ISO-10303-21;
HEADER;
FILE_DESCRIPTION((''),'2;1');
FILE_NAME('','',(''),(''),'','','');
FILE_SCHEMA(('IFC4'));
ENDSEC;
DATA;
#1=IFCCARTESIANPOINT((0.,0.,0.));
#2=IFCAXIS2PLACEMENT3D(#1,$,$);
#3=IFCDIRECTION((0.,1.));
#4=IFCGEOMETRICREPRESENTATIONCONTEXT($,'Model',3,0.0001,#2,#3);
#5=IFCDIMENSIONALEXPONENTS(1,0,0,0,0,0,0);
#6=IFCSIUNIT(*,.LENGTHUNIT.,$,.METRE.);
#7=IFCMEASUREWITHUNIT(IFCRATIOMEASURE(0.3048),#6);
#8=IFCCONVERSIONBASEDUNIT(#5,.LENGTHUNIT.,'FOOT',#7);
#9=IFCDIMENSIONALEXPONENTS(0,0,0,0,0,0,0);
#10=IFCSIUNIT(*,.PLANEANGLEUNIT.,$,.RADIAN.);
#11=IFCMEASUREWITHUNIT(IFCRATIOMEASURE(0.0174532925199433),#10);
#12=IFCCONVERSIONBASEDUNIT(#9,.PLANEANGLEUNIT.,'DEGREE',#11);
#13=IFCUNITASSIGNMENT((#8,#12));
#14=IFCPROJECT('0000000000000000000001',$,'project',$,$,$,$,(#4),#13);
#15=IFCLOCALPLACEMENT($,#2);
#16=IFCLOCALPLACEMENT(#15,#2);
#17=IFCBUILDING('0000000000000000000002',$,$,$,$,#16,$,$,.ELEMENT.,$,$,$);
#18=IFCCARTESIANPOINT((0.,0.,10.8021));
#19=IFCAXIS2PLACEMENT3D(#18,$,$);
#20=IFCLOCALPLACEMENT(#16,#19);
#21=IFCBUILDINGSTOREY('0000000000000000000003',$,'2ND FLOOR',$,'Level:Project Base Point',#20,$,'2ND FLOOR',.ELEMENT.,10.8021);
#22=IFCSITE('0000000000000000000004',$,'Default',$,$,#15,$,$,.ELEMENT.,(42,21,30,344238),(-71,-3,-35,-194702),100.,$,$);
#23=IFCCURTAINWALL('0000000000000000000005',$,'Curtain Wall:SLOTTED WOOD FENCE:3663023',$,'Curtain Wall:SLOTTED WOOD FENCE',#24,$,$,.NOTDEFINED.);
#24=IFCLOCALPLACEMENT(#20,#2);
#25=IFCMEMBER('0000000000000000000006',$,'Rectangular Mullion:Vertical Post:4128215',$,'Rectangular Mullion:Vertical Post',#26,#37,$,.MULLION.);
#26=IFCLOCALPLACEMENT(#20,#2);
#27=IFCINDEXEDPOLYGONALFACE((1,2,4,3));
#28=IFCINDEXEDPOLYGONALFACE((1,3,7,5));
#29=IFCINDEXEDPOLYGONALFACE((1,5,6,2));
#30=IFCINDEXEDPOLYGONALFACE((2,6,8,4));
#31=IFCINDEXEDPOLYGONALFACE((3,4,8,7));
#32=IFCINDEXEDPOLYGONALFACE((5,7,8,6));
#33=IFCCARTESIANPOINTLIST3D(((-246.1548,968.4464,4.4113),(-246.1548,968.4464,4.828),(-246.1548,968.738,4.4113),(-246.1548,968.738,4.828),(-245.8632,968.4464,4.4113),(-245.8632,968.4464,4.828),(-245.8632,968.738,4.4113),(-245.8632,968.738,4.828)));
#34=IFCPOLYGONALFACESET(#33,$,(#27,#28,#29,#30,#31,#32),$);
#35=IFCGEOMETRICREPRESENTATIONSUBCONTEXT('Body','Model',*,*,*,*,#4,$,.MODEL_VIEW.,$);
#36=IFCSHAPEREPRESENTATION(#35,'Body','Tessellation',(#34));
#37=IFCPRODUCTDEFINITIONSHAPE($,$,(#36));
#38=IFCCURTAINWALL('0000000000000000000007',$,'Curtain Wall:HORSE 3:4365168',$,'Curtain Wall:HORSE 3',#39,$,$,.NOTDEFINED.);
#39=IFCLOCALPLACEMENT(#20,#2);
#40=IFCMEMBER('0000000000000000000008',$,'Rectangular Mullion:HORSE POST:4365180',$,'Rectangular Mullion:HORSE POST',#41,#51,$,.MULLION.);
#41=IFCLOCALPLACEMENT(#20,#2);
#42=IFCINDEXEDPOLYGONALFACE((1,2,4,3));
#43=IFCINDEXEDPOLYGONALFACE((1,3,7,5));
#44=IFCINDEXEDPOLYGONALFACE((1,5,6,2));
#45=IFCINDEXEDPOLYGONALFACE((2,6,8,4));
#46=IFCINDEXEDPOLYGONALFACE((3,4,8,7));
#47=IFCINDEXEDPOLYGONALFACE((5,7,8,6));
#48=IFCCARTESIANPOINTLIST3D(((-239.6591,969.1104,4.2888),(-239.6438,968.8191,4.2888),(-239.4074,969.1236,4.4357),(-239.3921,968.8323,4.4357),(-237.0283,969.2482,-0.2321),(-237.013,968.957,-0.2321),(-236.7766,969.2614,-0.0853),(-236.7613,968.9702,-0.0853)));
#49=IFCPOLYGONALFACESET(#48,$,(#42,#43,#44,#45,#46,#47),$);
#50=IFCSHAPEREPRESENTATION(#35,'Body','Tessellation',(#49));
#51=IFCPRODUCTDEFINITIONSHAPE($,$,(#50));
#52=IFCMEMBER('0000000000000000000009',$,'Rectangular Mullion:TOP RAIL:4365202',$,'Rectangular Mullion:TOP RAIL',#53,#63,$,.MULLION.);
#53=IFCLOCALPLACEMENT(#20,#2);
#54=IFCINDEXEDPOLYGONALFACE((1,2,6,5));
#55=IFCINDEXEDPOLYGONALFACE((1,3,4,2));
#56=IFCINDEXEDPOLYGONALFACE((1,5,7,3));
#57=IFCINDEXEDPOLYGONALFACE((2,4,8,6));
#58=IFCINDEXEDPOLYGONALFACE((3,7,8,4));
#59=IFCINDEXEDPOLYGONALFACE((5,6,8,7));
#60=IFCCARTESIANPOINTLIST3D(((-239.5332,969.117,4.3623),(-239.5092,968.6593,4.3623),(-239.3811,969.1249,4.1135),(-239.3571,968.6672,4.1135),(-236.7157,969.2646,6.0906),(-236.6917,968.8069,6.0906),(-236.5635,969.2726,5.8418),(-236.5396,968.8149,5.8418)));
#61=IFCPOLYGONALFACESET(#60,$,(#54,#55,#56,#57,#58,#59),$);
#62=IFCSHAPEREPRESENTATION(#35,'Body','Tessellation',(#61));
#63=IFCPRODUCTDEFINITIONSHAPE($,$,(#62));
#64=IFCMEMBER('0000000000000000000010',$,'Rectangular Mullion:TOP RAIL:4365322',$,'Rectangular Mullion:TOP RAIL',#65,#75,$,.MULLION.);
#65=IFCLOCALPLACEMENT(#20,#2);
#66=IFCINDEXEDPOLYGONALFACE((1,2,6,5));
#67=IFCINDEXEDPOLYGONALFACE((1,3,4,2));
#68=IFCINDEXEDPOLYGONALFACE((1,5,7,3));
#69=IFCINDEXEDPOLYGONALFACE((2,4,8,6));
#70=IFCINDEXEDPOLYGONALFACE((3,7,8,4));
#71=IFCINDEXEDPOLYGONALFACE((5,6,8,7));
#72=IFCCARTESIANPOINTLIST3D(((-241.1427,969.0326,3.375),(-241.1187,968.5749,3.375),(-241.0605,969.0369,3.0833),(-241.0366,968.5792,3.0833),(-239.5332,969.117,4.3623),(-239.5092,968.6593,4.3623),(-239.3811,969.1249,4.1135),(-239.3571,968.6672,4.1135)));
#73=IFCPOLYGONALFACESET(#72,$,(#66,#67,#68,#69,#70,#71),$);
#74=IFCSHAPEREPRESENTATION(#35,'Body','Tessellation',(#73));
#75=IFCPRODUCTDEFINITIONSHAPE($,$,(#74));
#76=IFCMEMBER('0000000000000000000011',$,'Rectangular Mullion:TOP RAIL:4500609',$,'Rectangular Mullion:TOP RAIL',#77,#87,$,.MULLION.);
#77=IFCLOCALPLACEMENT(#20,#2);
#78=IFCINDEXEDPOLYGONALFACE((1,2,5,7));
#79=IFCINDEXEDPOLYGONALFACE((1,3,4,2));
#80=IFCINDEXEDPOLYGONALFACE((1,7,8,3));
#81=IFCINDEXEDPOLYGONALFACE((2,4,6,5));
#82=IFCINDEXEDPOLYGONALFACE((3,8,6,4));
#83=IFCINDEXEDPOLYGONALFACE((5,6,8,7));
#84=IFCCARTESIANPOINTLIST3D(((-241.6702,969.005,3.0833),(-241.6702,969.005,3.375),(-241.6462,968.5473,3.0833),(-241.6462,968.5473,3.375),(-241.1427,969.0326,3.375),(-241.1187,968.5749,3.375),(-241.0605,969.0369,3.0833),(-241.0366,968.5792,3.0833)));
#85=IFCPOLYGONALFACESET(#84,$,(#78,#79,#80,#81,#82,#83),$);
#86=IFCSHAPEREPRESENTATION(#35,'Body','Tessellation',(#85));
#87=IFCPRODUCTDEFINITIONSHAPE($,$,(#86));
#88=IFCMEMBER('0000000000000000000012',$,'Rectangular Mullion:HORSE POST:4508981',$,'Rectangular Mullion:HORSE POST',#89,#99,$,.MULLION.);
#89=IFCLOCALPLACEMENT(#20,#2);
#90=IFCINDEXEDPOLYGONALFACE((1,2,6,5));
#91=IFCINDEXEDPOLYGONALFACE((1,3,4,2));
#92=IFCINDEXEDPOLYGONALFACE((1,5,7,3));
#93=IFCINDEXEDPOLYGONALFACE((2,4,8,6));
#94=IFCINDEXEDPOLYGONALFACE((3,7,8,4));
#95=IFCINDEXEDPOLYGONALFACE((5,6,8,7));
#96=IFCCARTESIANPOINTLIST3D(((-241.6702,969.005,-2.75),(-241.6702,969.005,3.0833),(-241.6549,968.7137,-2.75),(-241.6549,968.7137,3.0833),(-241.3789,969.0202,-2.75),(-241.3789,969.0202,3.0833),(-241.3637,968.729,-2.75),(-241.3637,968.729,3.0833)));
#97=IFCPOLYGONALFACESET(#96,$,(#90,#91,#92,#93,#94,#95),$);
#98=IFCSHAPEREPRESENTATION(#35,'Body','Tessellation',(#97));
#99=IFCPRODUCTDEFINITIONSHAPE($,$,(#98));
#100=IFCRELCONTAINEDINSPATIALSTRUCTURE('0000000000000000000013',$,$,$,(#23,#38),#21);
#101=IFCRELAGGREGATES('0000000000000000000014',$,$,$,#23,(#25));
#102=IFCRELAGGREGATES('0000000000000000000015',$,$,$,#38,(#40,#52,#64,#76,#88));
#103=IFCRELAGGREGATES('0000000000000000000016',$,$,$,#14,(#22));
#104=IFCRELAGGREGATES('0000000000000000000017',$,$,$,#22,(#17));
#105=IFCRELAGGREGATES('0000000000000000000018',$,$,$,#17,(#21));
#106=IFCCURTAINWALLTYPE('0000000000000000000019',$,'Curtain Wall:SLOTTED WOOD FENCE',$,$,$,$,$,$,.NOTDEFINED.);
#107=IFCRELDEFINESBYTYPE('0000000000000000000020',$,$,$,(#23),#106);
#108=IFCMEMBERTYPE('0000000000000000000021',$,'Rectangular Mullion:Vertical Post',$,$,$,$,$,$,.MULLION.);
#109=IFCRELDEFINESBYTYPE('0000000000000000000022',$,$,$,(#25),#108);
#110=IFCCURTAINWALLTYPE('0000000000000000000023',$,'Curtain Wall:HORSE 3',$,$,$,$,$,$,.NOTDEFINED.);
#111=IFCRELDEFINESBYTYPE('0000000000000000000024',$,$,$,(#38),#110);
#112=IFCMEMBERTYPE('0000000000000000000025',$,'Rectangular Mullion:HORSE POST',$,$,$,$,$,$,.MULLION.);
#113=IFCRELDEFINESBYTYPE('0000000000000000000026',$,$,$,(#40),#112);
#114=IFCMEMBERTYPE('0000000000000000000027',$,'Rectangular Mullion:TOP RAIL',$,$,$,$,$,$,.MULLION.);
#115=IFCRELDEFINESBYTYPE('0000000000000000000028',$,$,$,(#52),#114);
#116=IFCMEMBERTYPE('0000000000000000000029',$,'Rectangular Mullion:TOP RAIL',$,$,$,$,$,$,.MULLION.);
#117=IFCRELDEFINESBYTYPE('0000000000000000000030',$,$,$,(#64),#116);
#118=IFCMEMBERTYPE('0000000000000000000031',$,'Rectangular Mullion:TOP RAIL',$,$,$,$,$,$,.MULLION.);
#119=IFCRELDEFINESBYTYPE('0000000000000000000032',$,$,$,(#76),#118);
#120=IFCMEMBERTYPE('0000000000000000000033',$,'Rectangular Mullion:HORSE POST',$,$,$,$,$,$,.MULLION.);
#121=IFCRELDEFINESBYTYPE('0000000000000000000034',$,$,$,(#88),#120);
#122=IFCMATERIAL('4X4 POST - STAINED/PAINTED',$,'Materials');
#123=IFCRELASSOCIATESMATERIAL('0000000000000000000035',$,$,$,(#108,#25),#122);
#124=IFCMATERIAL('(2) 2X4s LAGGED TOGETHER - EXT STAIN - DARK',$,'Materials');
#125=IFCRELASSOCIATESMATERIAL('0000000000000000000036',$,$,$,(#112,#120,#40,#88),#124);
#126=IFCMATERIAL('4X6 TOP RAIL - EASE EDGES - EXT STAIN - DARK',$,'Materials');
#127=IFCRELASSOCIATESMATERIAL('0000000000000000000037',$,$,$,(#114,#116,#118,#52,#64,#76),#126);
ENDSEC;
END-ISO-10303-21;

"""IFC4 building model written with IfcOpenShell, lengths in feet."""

from ifc_helpers import new_model, entity, si_unit, converted_unit, direction, frame, frame_2d, origin, origin_2d_with_axis, place, context, subcontext, project, spatial, rectangle, extrude, clip, halfspace, source, transform, mapped, material, material_profile, profile_set, profile_usage, type_object, type_shapes, element, aggregate, save


model = new_model("IFC4")

# Units and contexts
model_context = context("Model", 3, precision=0.0001, world=origin(), true_north=direction((0.0, 1.0)))
body_context = subcontext(model_context, "Body", "Model", "MODEL_VIEW")
ifc_project = project(units=[converted_unit("LENGTHUNIT", "FOOT", entity("IfcRatioMeasure", 0.3048), si_unit("LENGTHUNIT", "METRE"), dimensions=[1, 0, 0, 0, 0, 0, 0]), converted_unit("PLANEANGLEUNIT", "DEGREE", entity("IfcRatioMeasure", 0.0174532925199433), si_unit("PLANEANGLEUNIT", "RADIAN"), dimensions=[0, 0, 0, 0, 0, 0, 0])], contexts=[model_context])

# Site, building, storey
site_placement = place(None, origin())
site = spatial("IfcSite", under=ifc_project, at=site_placement, Name="Default", CompositionType="ELEMENT", RefLatitude=(42, 21, 30, 344238), RefLongitude=(-71, -3, -35, -194702), RefElevation=100.0)
building_placement = place(site_placement, origin())
building = spatial("IfcBuilding", under=site, at=building_placement, CompositionType="ELEMENT")
storey_placement = place(building_placement, frame((0.0, 0.0, 10.8021)))
storey = spatial("IfcBuildingStorey", under=building, at=storey_placement, Name="2ND FLOOR", ObjectType="Level:Project Base Point", LongName="2ND FLOOR", CompositionType="ELEMENT", Elevation=10.8021)

# Curtain wall, member
curtain_wall_type_1 = type_object("IfcCurtainWallType", Name="Curtain Wall:SLOTTED WOOD FENCE", PredefinedType="NOTDEFINED")
curtain_wall_1_placement = place(storey_placement, frame((0.0, 0.0, -10.8021)))
curtain_wall_1 = element("IfcCurtainWall", 1, at=curtain_wall_1_placement, inside=storey, type_object=curtain_wall_type_1, Name="Curtain Wall:SLOTTED WOOD FENCE:3663023", ObjectType="Curtain Wall:SLOTTED WOOD FENCE", PredefinedType="NOTDEFINED")
ifc_material_1 = material(Name="4X4 POST - STAINED/PAINTED", Category="Materials")
ifc_material_profile_1 = material_profile(ifc_material_1, rectangle(XDim=0.2917, YDim=0.2917, at=origin_2d_with_axis()), Name="Vertical Post")
ifc_profile_set_1 = profile_set([ifc_material_profile_1], Name="Vertical Post")
member_type_1 = type_object("IfcMemberType", Name="Rectangular Mullion:Vertical Post", PredefinedType="MULLION", material=ifc_profile_set_1)
shared_shape_1 = source(origin(), body_context, "Body", "SweptSolid", [
    extrude(rectangle(XDim=0.2917, YDim=0.2917, at=origin_2d_with_axis()), frame((0.0, 0.2083, -0.4167), z_axis=(0.0, 0.0, 1.0), x_axis=(0.0, -1.0, 0.0)), (0.0, 0.0, 1.0), 0.4167),
])
type_shapes(member_type_1, [shared_shape_1])
ifc_profile_usage_1 = profile_usage(ifc_profile_set_1)
member_1_placement = place(storey_placement, frame((-245.8007, 968.5922, 4.4113), z_axis=(0.0, 0.0, -1.0), x_axis=(0.0, -1.0, 0.0)))
member_1 = element("IfcMember", 2, at=member_1_placement, type_object=member_type_1, material=ifc_profile_usage_1, Name="Rectangular Mullion:Vertical Post:4128215", ObjectType="Rectangular Mullion:Vertical Post", PredefinedType="MULLION", context=body_context, shape_type="MappedRepresentation", body=[
    mapped(shared_shape_1, transform((0.0, 0.0, 0.0), scale=1.0)),
])
aggregate(curtain_wall_1, [member_1])

# Curtain wall, members
curtain_wall_type_2 = type_object("IfcCurtainWallType", Name="Curtain Wall:HORSE 3", PredefinedType="NOTDEFINED")
curtain_wall_2_placement = place(storey_placement, frame((0.0, 0.0, -10.8021)))
curtain_wall_2 = element("IfcCurtainWall", 3, at=curtain_wall_2_placement, inside=storey, type_object=curtain_wall_type_2, Name="Curtain Wall:HORSE 3:4365168", ObjectType="Curtain Wall:HORSE 3", PredefinedType="NOTDEFINED")
ifc_material_2 = material(Name="(2) 2X4s LAGGED TOGETHER - EXT STAIN - DARK", Category="Materials")
ifc_material_profile_2 = material_profile(ifc_material_2, rectangle(XDim=0.2917, YDim=0.2917, at=frame_2d((0.0, 0.0), x_axis=(1.0, 0.0))), Name="HORSE POST")
ifc_profile_set_2 = profile_set([ifc_material_profile_2], Name="HORSE POST")
ifc_profile_usage_2 = profile_usage(ifc_profile_set_2)
member_type_2 = type_object("IfcMemberType", Name="Rectangular Mullion:HORSE POST", PredefinedType="MULLION", material=ifc_profile_set_2)
shared_shape_2 = source(origin(), body_context, "Body", "SweptSolid", [
    extrude(rectangle(XDim=0.2917, YDim=0.2917, at=frame_2d((0.0, 0.0), x_axis=(1.0, 0.0))), frame((0.0, 0.1458, -5.2325), z_axis=(0.0, 0.0, 1.0), x_axis=(0.0, -1.0, 0.0)), (0.0, 0.0, 1.0), 5.2325),
])
type_shapes(member_type_2, [shared_shape_2])
placement = place(building_placement, frame((0.0, 0.0, 21.4688)))
member_2_placement = place(placement, frame((-236.8872, 968.9636, -10.8253), z_axis=(0.502782, 0.02635, -0.864011), x_axis=(-0.862827, -0.045219, -0.503472)))
member_2 = element("IfcMember", 4, at=member_2_placement, type_object=member_type_2, material=ifc_profile_usage_2, Name="Rectangular Mullion:HORSE POST:4365180", ObjectType="Rectangular Mullion:HORSE POST", PredefinedType="MULLION", context=body_context, shape_type="MappedRepresentation", body=[
    mapped(shared_shape_2, transform((0.0, 0.0, 0.0), scale=1.0)),
])
ifc_material_3 = material(Name="4X6 TOP RAIL - EASE EDGES - EXT STAIN - DARK", Category="Materials")
ifc_material_profile_3 = material_profile(ifc_material_3, rectangle(XDim=0.4583, YDim=0.2917, at=origin_2d_with_axis()), Name="TOP RAIL")
ifc_profile_set_3 = profile_set([ifc_material_profile_3], Name="TOP RAIL")
ifc_profile_usage_3 = profile_usage(ifc_profile_set_3)
member_type_3 = type_object("IfcMemberType", Name="Rectangular Mullion:TOP RAIL", PredefinedType="MULLION", material=ifc_profile_set_3)
shared_shape_3 = source(origin(), body_context, "Body", "SweptSolid", [
    extrude(rectangle(XDim=0.4583, YDim=0.2917, at=frame_2d((0.0, 0.0), x_axis=(1.0, 0.0))), frame((-0.1458, 0.0625, -3.3087), z_axis=(0.0, 0.0, 1.0), x_axis=(0.0, -1.0, 0.0)), (0.0, 0.0, 1.0), 3.3087),
])
type_shapes(member_type_3, [shared_shape_3])
member_3_placement = place(storey_placement, frame((-239.518, 968.8257, 4.3623), z_axis=(-0.851559, -0.044628, -0.522356), x_axis=(-0.52164, -0.027338, 0.852727)))
member_3 = element("IfcMember", 5, at=member_3_placement, type_object=member_type_3, material=ifc_profile_usage_3, Name="Rectangular Mullion:TOP RAIL:4365202", ObjectType="Rectangular Mullion:TOP RAIL", PredefinedType="MULLION", context=body_context, shape_type="MappedRepresentation", body=[
    mapped(shared_shape_3, transform((0.0, 0.0, 0.0), scale=1.0)),
])
ifc_profile_usage_4 = profile_usage(ifc_profile_set_3)
member_type_4 = type_object("IfcMemberType", Name="Rectangular Mullion:TOP RAIL", PredefinedType="MULLION", material=ifc_profile_set_3)
shared_shape_4 = source(origin(), body_context, "Body", "Clipping", [
    clip(extrude(rectangle(XDim=0.4583, YDim=0.2917, at=frame_2d((0.0, 0.0), x_axis=(1.0, 0.0))), frame((-0.1458, 0.0625, -1.89), z_axis=(0.0, 0.0, 1.0), x_axis=(0.0, -1.0, 0.0)), (0.0, 0.0, 1.0), 1.9722), halfspace(frame((0.0, 1.0, 0.0), z_axis=(0.27136, 0.0, 0.962478), x_axis=(0.962478, 0.0, -0.27136)), False)),
])
type_shapes(member_type_4, [shared_shape_4])
member_4_placement = place(storey_placement, frame((-241.1274, 968.7413, 3.375), z_axis=(-0.851559, -0.044628, -0.522356), x_axis=(-0.52164, -0.027338, 0.852727)))
member_4 = element("IfcMember", 6, at=member_4_placement, type_object=member_type_4, material=ifc_profile_usage_4, Name="Rectangular Mullion:TOP RAIL:4365322", ObjectType="Rectangular Mullion:TOP RAIL", PredefinedType="MULLION", context=body_context, shape_type="MappedRepresentation", body=[
    mapped(shared_shape_4, transform((0.0, 0.0, 0.0), scale=1.0)),
])
ifc_profile_usage_5 = profile_usage(ifc_profile_set_3)
member_type_5 = type_object("IfcMemberType", Name="Rectangular Mullion:TOP RAIL", PredefinedType="MULLION", material=ifc_profile_set_3)
shared_shape_5 = source(origin(), body_context, "Body", "Clipping", [
    clip(extrude(rectangle(XDim=0.4583, YDim=0.2917, at=origin_2d_with_axis()), frame((-0.1458, 0.0625, -0.6105), z_axis=(0.0, 0.0, 1.0), x_axis=(0.0, -1.0, 0.0)), (0.0, 0.0, 1.0), 0.6105), halfspace(frame((0.0, 1.0, -0.5283), z_axis=(0.27136, 0.0, -0.962478), x_axis=(0.962478, 0.0, 0.27136)), False)),
])
type_shapes(member_type_5, [shared_shape_5])
member_5_placement = place(storey_placement, frame((-241.6549, 968.7137, 3.375), z_axis=(-0.99863, -0.052336, 0.0), x_axis=(0.0, 0.0, 1.0)))
member_5 = element("IfcMember", 7, at=member_5_placement, type_object=member_type_5, material=ifc_profile_usage_5, Name="Rectangular Mullion:TOP RAIL:4500609", ObjectType="Rectangular Mullion:TOP RAIL", PredefinedType="MULLION", context=body_context, shape_type="MappedRepresentation", body=[
    mapped(shared_shape_5, transform((0.0, 0.0, 0.0), scale=1.0)),
])
ifc_profile_usage_6 = profile_usage(ifc_profile_set_2)
member_type_6 = type_object("IfcMemberType", Name="Rectangular Mullion:HORSE POST", PredefinedType="MULLION", material=ifc_profile_set_2)
shared_shape_6 = source(origin(), body_context, "Body", "SweptSolid", [
    extrude(rectangle(XDim=0.2917, YDim=0.2917, at=origin_2d_with_axis()), frame((-0.1458, 0.1458, -5.8333), z_axis=(0.0, 0.0, 1.0), x_axis=(0.0, -1.0, 0.0)), (0.0, 0.0, 1.0), 5.8333),
])
type_shapes(member_type_6, [shared_shape_6])
member_6_placement = place(storey_placement, frame((-241.6549, 968.7137, -2.75), z_axis=(0.0, 0.0, -1.0), x_axis=(-0.99863, -0.052336, 0.0)))
member_6 = element("IfcMember", 8, at=member_6_placement, type_object=member_type_6, material=ifc_profile_usage_6, Name="Rectangular Mullion:HORSE POST:4508981", ObjectType="Rectangular Mullion:HORSE POST", PredefinedType="MULLION", context=body_context, shape_type="MappedRepresentation", body=[
    mapped(shared_shape_6, transform((0.0, 0.0, 0.0), scale=1.0)),
])
aggregate(curtain_wall_2, [member_2, member_3, member_4, member_5, member_6])

save(model, "model.ifc")
